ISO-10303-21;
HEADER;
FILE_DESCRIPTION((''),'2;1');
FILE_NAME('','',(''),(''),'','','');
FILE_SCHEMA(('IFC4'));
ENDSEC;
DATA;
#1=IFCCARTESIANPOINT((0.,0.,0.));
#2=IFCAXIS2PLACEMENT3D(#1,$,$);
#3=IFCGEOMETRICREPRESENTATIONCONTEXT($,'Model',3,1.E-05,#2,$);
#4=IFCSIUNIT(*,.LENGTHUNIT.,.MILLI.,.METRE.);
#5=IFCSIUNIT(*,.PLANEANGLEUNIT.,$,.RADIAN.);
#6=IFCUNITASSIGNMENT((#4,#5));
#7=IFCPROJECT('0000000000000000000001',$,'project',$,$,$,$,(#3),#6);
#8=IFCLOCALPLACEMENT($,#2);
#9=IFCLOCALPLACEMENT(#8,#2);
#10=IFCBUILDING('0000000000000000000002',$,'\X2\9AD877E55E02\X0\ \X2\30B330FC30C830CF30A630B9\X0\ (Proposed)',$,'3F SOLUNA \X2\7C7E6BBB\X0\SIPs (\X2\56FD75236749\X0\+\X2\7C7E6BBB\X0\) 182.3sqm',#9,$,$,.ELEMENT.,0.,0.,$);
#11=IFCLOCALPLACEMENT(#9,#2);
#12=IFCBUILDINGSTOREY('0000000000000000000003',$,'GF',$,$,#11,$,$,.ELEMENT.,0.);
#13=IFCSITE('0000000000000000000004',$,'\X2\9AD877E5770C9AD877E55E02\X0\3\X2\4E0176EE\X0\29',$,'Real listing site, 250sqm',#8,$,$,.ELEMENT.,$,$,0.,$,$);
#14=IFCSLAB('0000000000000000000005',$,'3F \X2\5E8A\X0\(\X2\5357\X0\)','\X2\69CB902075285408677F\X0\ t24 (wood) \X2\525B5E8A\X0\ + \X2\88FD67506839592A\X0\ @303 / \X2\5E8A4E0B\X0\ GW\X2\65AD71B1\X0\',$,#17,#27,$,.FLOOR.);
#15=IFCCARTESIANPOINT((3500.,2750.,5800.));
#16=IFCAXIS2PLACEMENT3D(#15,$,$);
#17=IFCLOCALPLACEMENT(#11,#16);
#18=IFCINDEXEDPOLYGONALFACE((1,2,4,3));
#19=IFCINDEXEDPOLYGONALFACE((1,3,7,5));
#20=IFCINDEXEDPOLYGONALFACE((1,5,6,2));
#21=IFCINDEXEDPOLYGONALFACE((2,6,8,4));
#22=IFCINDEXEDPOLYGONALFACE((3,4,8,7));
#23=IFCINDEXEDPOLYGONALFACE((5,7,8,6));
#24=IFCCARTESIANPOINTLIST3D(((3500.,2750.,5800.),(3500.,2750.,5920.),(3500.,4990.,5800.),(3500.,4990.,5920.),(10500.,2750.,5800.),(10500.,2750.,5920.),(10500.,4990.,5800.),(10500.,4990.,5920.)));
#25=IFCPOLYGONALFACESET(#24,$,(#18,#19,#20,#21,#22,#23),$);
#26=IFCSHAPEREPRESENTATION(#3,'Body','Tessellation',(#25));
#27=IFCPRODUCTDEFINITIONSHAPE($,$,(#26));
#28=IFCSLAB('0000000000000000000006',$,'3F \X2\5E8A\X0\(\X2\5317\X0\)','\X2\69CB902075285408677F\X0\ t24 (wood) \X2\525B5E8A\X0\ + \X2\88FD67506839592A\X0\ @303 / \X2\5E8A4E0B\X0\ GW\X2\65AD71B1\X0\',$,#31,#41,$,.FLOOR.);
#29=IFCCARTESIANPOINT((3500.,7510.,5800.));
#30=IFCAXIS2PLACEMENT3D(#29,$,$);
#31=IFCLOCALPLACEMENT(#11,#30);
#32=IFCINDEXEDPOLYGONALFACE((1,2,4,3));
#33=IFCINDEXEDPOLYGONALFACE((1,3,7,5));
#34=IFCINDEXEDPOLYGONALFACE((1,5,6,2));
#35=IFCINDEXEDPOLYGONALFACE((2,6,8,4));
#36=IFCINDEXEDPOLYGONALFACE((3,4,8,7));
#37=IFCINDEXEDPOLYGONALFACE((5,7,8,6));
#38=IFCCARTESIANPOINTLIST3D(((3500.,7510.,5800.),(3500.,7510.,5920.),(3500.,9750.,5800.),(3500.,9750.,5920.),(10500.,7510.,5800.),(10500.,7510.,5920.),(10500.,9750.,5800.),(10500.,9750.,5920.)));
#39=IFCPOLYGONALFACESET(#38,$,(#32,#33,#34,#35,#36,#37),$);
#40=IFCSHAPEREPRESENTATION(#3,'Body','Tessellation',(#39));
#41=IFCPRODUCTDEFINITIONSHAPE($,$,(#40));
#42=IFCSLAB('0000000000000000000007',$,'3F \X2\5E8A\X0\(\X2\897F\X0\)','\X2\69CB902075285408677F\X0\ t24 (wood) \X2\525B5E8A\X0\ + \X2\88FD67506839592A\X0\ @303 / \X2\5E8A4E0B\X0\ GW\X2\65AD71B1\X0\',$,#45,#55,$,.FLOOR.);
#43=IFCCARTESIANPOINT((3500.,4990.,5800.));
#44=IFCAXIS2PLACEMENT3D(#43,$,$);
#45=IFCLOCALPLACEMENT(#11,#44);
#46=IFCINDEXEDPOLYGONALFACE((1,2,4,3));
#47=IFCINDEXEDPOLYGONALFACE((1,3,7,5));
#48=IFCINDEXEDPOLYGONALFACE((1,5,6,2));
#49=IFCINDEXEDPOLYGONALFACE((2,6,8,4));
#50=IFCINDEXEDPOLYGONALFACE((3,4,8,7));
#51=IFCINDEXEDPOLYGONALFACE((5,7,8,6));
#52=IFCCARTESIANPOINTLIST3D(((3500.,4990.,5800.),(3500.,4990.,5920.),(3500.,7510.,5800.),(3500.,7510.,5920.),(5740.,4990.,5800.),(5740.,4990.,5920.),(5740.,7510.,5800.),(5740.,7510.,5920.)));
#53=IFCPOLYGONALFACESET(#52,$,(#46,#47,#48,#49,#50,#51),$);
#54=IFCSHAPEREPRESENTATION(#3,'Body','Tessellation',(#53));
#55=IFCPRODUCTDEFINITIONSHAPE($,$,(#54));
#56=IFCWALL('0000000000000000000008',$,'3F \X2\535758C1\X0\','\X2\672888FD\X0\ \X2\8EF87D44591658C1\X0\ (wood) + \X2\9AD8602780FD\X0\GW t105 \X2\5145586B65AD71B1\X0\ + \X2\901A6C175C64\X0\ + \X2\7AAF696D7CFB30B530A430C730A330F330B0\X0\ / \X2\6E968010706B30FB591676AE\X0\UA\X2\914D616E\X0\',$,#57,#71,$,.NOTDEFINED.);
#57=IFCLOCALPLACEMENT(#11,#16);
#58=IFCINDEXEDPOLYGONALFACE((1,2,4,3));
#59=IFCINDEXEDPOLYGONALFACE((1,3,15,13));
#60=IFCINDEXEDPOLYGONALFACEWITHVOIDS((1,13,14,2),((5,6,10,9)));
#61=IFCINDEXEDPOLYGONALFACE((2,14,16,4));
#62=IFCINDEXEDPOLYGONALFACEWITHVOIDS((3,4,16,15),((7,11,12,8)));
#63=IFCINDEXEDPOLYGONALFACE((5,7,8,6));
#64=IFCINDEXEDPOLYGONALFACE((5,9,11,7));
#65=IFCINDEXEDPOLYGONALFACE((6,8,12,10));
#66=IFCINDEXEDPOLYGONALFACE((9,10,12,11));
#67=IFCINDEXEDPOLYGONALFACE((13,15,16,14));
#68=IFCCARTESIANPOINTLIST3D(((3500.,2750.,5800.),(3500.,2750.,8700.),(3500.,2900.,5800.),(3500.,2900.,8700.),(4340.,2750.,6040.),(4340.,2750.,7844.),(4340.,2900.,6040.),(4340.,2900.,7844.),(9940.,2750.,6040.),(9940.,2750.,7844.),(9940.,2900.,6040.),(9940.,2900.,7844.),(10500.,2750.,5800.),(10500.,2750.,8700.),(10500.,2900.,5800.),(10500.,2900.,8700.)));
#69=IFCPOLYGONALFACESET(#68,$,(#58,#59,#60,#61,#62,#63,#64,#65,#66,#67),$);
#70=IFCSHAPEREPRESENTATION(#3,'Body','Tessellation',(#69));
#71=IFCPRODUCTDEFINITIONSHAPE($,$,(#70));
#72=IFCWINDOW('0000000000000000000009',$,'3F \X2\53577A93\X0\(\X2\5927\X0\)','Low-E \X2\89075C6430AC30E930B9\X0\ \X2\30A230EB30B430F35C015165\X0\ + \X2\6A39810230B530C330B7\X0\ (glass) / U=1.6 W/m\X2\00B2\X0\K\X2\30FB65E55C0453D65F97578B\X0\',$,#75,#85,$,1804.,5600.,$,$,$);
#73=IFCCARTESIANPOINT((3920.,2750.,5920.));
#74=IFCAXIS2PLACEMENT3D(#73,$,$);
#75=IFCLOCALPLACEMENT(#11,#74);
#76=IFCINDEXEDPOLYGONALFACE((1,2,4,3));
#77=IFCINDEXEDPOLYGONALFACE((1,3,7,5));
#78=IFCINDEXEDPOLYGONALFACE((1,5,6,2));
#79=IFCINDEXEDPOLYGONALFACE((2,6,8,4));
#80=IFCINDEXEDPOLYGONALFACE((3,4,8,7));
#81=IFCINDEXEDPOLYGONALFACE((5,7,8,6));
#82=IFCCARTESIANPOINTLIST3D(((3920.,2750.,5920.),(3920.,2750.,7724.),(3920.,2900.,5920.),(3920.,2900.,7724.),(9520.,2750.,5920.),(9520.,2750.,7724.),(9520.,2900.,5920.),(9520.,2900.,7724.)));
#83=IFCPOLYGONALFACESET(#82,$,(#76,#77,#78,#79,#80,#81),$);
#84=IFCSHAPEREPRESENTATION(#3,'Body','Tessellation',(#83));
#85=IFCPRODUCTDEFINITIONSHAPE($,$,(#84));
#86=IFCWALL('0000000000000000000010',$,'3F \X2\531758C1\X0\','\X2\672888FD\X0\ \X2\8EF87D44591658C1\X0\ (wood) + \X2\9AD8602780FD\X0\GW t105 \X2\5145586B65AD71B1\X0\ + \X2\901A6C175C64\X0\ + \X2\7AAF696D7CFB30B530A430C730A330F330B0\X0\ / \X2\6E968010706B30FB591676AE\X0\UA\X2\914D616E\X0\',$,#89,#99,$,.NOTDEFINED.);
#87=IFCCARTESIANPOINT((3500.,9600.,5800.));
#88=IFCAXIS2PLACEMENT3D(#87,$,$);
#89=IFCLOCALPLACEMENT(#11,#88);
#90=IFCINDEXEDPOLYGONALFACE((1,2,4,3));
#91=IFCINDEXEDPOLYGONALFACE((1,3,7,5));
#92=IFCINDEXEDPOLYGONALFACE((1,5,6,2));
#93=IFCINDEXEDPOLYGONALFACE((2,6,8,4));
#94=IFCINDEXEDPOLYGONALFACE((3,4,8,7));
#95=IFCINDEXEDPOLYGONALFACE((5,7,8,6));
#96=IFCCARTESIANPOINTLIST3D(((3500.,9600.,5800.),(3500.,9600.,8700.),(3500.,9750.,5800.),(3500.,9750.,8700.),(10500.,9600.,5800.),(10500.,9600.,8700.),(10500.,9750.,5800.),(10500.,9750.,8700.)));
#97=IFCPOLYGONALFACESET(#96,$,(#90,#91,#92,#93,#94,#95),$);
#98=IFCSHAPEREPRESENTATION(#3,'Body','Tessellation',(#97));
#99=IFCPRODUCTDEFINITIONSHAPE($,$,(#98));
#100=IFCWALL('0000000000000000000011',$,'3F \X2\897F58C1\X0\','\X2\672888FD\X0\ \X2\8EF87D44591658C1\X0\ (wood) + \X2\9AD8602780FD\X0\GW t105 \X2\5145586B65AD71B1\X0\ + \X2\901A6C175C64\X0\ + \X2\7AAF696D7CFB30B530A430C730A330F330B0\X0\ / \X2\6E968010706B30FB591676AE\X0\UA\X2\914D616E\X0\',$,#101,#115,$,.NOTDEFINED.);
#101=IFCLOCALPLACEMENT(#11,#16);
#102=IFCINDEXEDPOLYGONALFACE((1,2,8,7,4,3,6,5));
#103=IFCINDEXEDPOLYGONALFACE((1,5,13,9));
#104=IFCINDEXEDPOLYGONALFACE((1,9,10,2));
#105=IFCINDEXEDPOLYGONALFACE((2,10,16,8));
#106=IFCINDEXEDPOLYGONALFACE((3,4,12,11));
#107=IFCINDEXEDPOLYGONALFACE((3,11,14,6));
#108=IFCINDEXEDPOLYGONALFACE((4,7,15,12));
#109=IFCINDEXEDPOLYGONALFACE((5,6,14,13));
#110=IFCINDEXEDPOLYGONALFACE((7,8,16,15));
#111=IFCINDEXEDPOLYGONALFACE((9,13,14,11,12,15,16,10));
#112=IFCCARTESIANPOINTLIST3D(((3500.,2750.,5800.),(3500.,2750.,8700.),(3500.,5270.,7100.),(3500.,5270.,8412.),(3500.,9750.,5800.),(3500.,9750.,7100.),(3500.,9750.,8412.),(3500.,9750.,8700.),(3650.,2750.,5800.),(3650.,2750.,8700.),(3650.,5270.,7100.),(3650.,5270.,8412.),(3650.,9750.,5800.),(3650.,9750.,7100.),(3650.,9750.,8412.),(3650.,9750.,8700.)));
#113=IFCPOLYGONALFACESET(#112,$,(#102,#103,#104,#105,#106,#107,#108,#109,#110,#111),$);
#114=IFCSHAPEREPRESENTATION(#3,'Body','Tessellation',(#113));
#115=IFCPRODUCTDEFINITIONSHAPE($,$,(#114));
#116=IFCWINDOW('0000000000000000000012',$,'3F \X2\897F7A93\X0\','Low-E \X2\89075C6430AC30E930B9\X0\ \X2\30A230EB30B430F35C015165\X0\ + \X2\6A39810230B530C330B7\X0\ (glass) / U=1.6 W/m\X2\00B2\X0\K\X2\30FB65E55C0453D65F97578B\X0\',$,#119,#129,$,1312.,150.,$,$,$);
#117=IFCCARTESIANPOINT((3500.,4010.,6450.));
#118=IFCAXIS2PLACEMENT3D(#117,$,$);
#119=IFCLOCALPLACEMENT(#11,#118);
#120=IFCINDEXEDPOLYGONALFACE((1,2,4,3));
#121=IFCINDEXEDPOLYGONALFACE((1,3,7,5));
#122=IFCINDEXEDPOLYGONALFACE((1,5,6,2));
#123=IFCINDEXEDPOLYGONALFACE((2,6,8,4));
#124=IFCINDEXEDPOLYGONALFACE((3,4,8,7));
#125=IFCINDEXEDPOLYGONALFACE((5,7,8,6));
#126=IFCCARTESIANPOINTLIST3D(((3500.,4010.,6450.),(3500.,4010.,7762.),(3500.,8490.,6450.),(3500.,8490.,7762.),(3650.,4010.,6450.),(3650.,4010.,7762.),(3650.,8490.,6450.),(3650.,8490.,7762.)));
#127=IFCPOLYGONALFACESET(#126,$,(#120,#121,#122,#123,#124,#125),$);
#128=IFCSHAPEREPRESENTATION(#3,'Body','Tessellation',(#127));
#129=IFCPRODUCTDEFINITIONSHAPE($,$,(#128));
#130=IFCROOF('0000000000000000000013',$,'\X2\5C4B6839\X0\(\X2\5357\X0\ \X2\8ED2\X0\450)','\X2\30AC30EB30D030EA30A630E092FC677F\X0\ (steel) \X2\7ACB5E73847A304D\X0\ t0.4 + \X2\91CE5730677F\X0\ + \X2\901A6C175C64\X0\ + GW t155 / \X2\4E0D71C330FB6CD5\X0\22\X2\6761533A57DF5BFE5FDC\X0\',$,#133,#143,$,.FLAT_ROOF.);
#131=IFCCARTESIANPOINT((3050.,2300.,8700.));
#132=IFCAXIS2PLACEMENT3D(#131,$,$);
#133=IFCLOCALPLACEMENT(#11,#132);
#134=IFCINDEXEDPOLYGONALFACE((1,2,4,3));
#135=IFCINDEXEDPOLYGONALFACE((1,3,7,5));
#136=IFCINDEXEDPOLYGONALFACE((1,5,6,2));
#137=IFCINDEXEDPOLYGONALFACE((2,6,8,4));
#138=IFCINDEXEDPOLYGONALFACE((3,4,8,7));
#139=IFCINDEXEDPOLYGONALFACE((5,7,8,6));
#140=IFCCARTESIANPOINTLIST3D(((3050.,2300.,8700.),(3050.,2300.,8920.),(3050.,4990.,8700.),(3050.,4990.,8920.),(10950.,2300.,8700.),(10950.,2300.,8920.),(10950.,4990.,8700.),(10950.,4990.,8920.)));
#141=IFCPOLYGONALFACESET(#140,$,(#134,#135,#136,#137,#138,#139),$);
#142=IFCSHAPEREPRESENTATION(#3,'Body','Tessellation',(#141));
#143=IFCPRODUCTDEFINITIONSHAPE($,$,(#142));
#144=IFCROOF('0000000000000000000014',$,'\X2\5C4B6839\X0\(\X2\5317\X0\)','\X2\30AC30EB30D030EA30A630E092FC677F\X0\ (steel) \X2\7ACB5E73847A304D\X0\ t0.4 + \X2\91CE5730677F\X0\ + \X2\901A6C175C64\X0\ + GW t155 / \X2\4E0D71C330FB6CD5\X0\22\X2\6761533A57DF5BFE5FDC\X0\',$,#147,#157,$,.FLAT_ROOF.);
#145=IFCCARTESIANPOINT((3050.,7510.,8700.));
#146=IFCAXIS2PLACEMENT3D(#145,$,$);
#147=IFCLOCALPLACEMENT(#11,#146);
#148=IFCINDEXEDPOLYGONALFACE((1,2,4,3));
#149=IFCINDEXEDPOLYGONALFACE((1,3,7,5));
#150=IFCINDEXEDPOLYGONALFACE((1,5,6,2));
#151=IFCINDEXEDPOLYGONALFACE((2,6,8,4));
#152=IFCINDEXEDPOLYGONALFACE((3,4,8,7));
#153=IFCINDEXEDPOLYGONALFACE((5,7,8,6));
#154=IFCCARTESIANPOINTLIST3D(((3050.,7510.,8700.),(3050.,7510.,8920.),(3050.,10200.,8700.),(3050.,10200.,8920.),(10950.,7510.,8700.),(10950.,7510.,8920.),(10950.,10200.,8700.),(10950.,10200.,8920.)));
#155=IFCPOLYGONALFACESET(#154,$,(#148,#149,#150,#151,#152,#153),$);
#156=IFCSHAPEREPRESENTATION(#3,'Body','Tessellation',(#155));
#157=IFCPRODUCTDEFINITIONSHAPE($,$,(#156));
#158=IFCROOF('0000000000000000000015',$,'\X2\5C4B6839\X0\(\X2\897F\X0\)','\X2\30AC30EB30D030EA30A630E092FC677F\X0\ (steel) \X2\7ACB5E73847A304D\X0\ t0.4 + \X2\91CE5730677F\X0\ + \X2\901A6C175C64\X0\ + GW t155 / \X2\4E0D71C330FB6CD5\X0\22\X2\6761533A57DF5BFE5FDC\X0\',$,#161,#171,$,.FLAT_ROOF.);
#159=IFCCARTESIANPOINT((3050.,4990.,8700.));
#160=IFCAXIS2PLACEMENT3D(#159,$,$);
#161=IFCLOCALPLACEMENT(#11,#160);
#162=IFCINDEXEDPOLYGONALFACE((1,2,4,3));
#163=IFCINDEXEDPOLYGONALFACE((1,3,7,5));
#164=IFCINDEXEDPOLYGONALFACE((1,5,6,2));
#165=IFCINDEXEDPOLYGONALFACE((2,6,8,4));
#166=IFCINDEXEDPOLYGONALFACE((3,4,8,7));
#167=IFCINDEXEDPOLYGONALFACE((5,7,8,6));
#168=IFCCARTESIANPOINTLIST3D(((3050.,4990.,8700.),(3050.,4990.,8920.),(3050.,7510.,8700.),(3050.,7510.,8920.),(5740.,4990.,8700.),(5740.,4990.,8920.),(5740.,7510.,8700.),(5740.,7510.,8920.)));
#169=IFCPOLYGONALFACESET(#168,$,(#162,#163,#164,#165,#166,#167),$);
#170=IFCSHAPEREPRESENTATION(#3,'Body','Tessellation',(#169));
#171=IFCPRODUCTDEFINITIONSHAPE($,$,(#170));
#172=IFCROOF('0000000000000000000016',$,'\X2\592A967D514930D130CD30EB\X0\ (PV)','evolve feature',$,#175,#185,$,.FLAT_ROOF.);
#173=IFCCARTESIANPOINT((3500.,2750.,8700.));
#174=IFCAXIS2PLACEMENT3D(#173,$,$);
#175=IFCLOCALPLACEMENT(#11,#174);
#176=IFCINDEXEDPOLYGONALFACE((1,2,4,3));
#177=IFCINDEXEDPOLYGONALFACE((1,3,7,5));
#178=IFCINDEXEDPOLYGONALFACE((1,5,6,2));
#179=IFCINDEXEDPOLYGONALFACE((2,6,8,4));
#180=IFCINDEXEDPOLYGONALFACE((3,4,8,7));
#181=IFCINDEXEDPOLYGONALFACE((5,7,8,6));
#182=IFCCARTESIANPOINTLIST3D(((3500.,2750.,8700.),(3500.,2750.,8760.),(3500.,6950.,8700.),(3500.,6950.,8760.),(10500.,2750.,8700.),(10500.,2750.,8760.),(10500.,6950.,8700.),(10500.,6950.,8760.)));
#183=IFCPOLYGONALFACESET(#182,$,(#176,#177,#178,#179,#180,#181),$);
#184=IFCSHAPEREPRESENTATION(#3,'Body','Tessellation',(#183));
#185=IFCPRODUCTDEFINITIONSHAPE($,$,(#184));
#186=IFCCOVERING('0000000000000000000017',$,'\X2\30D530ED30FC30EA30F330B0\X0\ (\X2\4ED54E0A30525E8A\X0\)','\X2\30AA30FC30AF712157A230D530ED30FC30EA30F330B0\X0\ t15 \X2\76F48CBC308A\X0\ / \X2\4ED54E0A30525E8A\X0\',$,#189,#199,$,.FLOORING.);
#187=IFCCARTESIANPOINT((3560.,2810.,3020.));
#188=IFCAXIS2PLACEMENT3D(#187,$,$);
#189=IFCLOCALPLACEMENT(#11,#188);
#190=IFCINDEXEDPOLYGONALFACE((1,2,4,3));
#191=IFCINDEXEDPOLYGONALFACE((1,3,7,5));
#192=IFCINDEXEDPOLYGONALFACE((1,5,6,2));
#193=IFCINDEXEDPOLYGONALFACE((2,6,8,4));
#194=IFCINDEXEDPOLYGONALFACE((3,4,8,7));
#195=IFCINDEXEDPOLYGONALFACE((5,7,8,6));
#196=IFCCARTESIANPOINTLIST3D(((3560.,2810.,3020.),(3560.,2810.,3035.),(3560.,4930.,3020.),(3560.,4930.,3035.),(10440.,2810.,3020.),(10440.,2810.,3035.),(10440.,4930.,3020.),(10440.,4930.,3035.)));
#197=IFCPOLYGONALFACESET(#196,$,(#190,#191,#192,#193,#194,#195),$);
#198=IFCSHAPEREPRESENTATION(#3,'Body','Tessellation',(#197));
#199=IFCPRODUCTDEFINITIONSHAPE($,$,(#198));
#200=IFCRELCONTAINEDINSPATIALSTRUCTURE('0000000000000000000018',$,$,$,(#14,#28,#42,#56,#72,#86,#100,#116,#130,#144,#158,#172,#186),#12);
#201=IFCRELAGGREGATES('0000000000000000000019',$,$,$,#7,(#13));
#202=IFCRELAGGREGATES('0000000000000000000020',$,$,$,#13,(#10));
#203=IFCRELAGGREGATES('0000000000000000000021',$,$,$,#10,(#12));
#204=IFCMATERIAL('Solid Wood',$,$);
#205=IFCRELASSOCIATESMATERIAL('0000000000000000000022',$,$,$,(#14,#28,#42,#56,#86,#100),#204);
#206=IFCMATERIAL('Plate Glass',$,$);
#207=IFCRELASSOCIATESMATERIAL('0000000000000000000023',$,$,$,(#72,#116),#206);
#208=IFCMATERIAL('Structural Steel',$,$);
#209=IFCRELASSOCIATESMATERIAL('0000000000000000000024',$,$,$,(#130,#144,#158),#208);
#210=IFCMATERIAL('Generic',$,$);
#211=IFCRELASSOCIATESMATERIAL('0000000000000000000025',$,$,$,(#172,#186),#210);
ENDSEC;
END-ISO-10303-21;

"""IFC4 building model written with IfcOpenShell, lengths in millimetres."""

from ifc_helpers import new_model, si_unit, frame, frame_2d, origin, place, context, project, spatial, rectangle, extrude, material, element, fill, save


model = new_model("IFC4")

# Units and contexts
model_context = context("Model", 3, precision=1e-05, world=origin())
ifc_project = project(units=[si_unit("LENGTHUNIT", "METRE", prefix="MILLI"), si_unit("PLANEANGLEUNIT", "RADIAN")], contexts=[model_context])

# Site, building, storey
site_placement = place(None, origin())
site = spatial("IfcSite", under=ifc_project, at=site_placement, Name="高知県高知市3丁目29", ObjectType="Real listing site, 250sqm", CompositionType="ELEMENT", RefElevation=0.0)
building_placement = place(site_placement, origin())
building = spatial("IfcBuilding", under=site, at=building_placement, Name="高知市 コートハウス (Proposed)", ObjectType="3F SOLUNA 籾殻SIPs (国産杉+籾殻) 182.3sqm", CompositionType="ELEMENT", ElevationOfRefHeight=0.0, ElevationOfTerrain=0.0)
storey_placement = place(building_placement, origin())
storey = spatial("IfcBuildingStorey", under=building, at=storey_placement, Name="GF", CompositionType="ELEMENT", Elevation=0.0)

# Slabs
ifc_material_1 = material(Name="Solid Wood")
slab_1_placement = place(storey_placement, frame((3500.0, 2750.0, 5800.0)))
element("IfcSlab", 1, at=slab_1_placement, inside=storey, material=ifc_material_1, Name="3F 床(南)", Description="構造用合板 t24 (wood) 剛床 + 製材根太 @303 / 床下 GW断熱", PredefinedType="FLOOR", context=model_context, shape_type="SweptSolid", body=[
    extrude(rectangle(XDim=7000.0, YDim=2240.0, at=frame_2d((3500.0, 1120.0))), frame((3500.0, 2750.0, 5800.0)), (0.0, 0.0, 1.0), 120.0),
])
slab_2_placement = place(storey_placement, frame((3500.0, 7510.0, 5800.0)))
element("IfcSlab", 2, at=slab_2_placement, inside=storey, material=ifc_material_1, Name="3F 床(北)", Description="構造用合板 t24 (wood) 剛床 + 製材根太 @303 / 床下 GW断熱", PredefinedType="FLOOR", context=model_context, shape_type="SweptSolid", body=[
    extrude(rectangle(XDim=7000.0, YDim=2240.0, at=frame_2d((3500.0, 1120.0))), frame((3500.0, 7510.0, 5800.0)), (0.0, 0.0, 1.0), 120.0),
])
slab_3_placement = place(storey_placement, frame((3500.0, 4990.0, 5800.0)))
element("IfcSlab", 3, at=slab_3_placement, inside=storey, material=ifc_material_1, Name="3F 床(西)", Description="構造用合板 t24 (wood) 剛床 + 製材根太 @303 / 床下 GW断熱", PredefinedType="FLOOR", context=model_context, shape_type="SweptSolid", body=[
    extrude(rectangle(XDim=2240.0, YDim=2520.0, at=frame_2d((1120.0, 1260.0))), frame((3500.0, 4990.0, 5800.0)), (0.0, 0.0, 1.0), 120.0),
])

# Wall, opening, window
wall_1_placement = place(storey_placement, frame((3500.0, 2750.0, 5800.0)))
wall_1 = element("IfcWall", 4, at=wall_1_placement, inside=storey, material=ifc_material_1, Name="3F 南壁", Description="木製 軸組外壁 (wood) + 高性能GW t105 充填断熱 + 通気層 + 窯業系サイディング / 準耐火・外皮UA配慮", PredefinedType="NOTDEFINED", context=model_context, shape_type="SweptSolid", body=[
    extrude(rectangle(XDim=7000.0, YDim=150.0, at=frame_2d((3500.0, 75.0))), frame((3500.0, 2750.0, 5800.0)), (0.0, 0.0, 1.0), 2900.0),
])
opening_1_placement = place(storey_placement, frame((3920.0, 2750.0, 5920.0)))
opening_1 = element("IfcOpeningElement", 5, at=opening_1_placement, cuts=wall_1, PredefinedType="NOTDEFINED", context=model_context, shape_type="SweptSolid", body=[
    extrude(rectangle(XDim=5600.0, YDim=150.0, at=frame_2d((2800.0, 75.0))), frame((3920.0, 2750.0, 5920.0)), (0.0, 0.0, 1.0), 1804.0),
])
ifc_material_2 = material(Name="Plate Glass")
window_1_placement = place(storey_placement, frame((3920.0, 2750.0, 5920.0)))
window_1 = element("IfcWindow", 6, at=window_1_placement, inside=storey, material=ifc_material_2, Name="3F 南窓(大)", Description="Low-E 複層ガラス アルゴン封入 + 樹脂サッシ (glass) / U=1.6 W/m²K・日射取得型", OverallHeight=1804.0, OverallWidth=5600.0, context=model_context, shape_type="SweptSolid", body=[
    extrude(rectangle(XDim=5600.0, YDim=150.0, at=frame_2d((2800.0, 75.0))), frame((3920.0, 2750.0, 5920.0)), (0.0, 0.0, 1.0), 1804.0),
])
fill(opening_1, window_1)

# Wall
wall_2_placement = place(storey_placement, frame((3500.0, 9600.0, 5800.0)))
element("IfcWall", 7, at=wall_2_placement, inside=storey, material=ifc_material_1, Name="3F 北壁", Description="木製 軸組外壁 (wood) + 高性能GW t105 充填断熱 + 通気層 + 窯業系サイディング / 準耐火・外皮UA配慮", PredefinedType="NOTDEFINED", context=model_context, shape_type="SweptSolid", body=[
    extrude(rectangle(XDim=7000.0, YDim=150.0, at=frame_2d((3500.0, 75.0))), frame((3500.0, 9600.0, 5800.0)), (0.0, 0.0, 1.0), 2900.0),
])

# Wall, opening, window
wall_3_placement = place(storey_placement, frame((3500.0, 2750.0, 5800.0)))
wall_3 = element("IfcWall", 8, at=wall_3_placement, inside=storey, material=ifc_material_1, Name="3F 西壁", Description="木製 軸組外壁 (wood) + 高性能GW t105 充填断熱 + 通気層 + 窯業系サイディング / 準耐火・外皮UA配慮", PredefinedType="NOTDEFINED", context=model_context, shape_type="SweptSolid", body=[
    extrude(rectangle(XDim=150.0, YDim=7000.0, at=frame_2d((75.0, 3500.0))), frame((3500.0, 2750.0, 5800.0)), (0.0, 0.0, 1.0), 2900.0),
])
opening_2_placement = place(storey_placement, frame((3500.0, 4010.0, 6450.0)))
opening_2 = element("IfcOpeningElement", 9, at=opening_2_placement, cuts=wall_3, PredefinedType="NOTDEFINED", context=model_context, shape_type="SweptSolid", body=[
    extrude(rectangle(XDim=150.0, YDim=4480.0, at=frame_2d((75.0, 2240.0))), frame((3500.0, 4010.0, 6450.0)), (0.0, 0.0, 1.0), 1312.0),
])
window_2_placement = place(storey_placement, frame((3500.0, 4010.0, 6450.0)))
window_2 = element("IfcWindow", 10, at=window_2_placement, inside=storey, material=ifc_material_2, Name="3F 西窓", Description="Low-E 複層ガラス アルゴン封入 + 樹脂サッシ (glass) / U=1.6 W/m²K・日射取得型", OverallHeight=1312.0, OverallWidth=150.0, context=model_context, shape_type="SweptSolid", body=[
    extrude(rectangle(XDim=150.0, YDim=4480.0, at=frame_2d((75.0, 2240.0))), frame((3500.0, 4010.0, 6450.0)), (0.0, 0.0, 1.0), 1312.0),
])
fill(opening_2, window_2)

# Roofs
ifc_material_3 = material(Name="Structural Steel")
roof_1_placement = place(storey_placement, frame((3050.0, 2300.0, 8700.0)))
element("IfcRoof", 11, at=roof_1_placement, inside=storey, material=ifc_material_3, Name="屋根(南 軒450)", Description="ガルバリウム鋼板 (steel) 立平葺き t0.4 + 野地板 + 通気層 + GW t155 / 不燃・法22条区域対応", PredefinedType="FLAT_ROOF", context=model_context, shape_type="SweptSolid", body=[
    extrude(rectangle(XDim=7900.0, YDim=2690.0, at=frame_2d((3950.0, 1345.0))), frame((3050.0, 2300.0, 8700.0)), (0.0, 0.0, 1.0), 220.0),
])
roof_2_placement = place(storey_placement, frame((3050.0, 7510.0, 8700.0)))
element("IfcRoof", 12, at=roof_2_placement, inside=storey, material=ifc_material_3, Name="屋根(北)", Description="ガルバリウム鋼板 (steel) 立平葺き t0.4 + 野地板 + 通気層 + GW t155 / 不燃・法22条区域対応", PredefinedType="FLAT_ROOF", context=model_context, shape_type="SweptSolid", body=[
    extrude(rectangle(XDim=7900.0, YDim=2690.0, at=frame_2d((3950.0, 1345.0))), frame((3050.0, 7510.0, 8700.0)), (0.0, 0.0, 1.0), 220.0),
])
roof_3_placement = place(storey_placement, frame((3050.0, 4990.0, 8700.0)))
element("IfcRoof", 13, at=roof_3_placement, inside=storey, material=ifc_material_3, Name="屋根(西)", Description="ガルバリウム鋼板 (steel) 立平葺き t0.4 + 野地板 + 通気層 + GW t155 / 不燃・法22条区域対応", PredefinedType="FLAT_ROOF", context=model_context, shape_type="SweptSolid", body=[
    extrude(rectangle(XDim=2690.0, YDim=2520.0, at=frame_2d((1345.0, 1260.0))), frame((3050.0, 4990.0, 8700.0)), (0.0, 0.0, 1.0), 220.0),
])
ifc_material_4 = material(Name="Generic")
roof_4_placement = place(storey_placement, frame((3500.0, 2750.0, 8700.0)))
element("IfcRoof", 14, at=roof_4_placement, inside=storey, material=ifc_material_4, Name="太陽光パネル (PV)", Description="evolve feature", PredefinedType="FLAT_ROOF", context=model_context, shape_type="SweptSolid", body=[
    extrude(rectangle(XDim=7000.0, YDim=4200.0, at=frame_2d((3500.0, 2100.0))), frame((3500.0, 2750.0, 8700.0)), (0.0, 0.0, 1.0), 60.0),
])

# Covering
covering_1_placement = place(storey_placement, frame((3560.0, 2810.0, 3020.0)))
element("IfcCovering", 15, at=covering_1_placement, inside=storey, material=ifc_material_4, Name="フローリング (仕上げ床)", Description="オーク無垢フローリング t15 直貼り / 仕上げ床", PredefinedType="FLOORING", context=model_context, shape_type="SweptSolid", body=[
    extrude(rectangle(XDim=6880.0, YDim=2120.0, at=frame_2d((3440.0, 1060.0))), frame((3560.0, 2810.0, 3020.0)), (0.0, 0.0, 1.0), 15.0),
])

save(model, "model.ifc")
